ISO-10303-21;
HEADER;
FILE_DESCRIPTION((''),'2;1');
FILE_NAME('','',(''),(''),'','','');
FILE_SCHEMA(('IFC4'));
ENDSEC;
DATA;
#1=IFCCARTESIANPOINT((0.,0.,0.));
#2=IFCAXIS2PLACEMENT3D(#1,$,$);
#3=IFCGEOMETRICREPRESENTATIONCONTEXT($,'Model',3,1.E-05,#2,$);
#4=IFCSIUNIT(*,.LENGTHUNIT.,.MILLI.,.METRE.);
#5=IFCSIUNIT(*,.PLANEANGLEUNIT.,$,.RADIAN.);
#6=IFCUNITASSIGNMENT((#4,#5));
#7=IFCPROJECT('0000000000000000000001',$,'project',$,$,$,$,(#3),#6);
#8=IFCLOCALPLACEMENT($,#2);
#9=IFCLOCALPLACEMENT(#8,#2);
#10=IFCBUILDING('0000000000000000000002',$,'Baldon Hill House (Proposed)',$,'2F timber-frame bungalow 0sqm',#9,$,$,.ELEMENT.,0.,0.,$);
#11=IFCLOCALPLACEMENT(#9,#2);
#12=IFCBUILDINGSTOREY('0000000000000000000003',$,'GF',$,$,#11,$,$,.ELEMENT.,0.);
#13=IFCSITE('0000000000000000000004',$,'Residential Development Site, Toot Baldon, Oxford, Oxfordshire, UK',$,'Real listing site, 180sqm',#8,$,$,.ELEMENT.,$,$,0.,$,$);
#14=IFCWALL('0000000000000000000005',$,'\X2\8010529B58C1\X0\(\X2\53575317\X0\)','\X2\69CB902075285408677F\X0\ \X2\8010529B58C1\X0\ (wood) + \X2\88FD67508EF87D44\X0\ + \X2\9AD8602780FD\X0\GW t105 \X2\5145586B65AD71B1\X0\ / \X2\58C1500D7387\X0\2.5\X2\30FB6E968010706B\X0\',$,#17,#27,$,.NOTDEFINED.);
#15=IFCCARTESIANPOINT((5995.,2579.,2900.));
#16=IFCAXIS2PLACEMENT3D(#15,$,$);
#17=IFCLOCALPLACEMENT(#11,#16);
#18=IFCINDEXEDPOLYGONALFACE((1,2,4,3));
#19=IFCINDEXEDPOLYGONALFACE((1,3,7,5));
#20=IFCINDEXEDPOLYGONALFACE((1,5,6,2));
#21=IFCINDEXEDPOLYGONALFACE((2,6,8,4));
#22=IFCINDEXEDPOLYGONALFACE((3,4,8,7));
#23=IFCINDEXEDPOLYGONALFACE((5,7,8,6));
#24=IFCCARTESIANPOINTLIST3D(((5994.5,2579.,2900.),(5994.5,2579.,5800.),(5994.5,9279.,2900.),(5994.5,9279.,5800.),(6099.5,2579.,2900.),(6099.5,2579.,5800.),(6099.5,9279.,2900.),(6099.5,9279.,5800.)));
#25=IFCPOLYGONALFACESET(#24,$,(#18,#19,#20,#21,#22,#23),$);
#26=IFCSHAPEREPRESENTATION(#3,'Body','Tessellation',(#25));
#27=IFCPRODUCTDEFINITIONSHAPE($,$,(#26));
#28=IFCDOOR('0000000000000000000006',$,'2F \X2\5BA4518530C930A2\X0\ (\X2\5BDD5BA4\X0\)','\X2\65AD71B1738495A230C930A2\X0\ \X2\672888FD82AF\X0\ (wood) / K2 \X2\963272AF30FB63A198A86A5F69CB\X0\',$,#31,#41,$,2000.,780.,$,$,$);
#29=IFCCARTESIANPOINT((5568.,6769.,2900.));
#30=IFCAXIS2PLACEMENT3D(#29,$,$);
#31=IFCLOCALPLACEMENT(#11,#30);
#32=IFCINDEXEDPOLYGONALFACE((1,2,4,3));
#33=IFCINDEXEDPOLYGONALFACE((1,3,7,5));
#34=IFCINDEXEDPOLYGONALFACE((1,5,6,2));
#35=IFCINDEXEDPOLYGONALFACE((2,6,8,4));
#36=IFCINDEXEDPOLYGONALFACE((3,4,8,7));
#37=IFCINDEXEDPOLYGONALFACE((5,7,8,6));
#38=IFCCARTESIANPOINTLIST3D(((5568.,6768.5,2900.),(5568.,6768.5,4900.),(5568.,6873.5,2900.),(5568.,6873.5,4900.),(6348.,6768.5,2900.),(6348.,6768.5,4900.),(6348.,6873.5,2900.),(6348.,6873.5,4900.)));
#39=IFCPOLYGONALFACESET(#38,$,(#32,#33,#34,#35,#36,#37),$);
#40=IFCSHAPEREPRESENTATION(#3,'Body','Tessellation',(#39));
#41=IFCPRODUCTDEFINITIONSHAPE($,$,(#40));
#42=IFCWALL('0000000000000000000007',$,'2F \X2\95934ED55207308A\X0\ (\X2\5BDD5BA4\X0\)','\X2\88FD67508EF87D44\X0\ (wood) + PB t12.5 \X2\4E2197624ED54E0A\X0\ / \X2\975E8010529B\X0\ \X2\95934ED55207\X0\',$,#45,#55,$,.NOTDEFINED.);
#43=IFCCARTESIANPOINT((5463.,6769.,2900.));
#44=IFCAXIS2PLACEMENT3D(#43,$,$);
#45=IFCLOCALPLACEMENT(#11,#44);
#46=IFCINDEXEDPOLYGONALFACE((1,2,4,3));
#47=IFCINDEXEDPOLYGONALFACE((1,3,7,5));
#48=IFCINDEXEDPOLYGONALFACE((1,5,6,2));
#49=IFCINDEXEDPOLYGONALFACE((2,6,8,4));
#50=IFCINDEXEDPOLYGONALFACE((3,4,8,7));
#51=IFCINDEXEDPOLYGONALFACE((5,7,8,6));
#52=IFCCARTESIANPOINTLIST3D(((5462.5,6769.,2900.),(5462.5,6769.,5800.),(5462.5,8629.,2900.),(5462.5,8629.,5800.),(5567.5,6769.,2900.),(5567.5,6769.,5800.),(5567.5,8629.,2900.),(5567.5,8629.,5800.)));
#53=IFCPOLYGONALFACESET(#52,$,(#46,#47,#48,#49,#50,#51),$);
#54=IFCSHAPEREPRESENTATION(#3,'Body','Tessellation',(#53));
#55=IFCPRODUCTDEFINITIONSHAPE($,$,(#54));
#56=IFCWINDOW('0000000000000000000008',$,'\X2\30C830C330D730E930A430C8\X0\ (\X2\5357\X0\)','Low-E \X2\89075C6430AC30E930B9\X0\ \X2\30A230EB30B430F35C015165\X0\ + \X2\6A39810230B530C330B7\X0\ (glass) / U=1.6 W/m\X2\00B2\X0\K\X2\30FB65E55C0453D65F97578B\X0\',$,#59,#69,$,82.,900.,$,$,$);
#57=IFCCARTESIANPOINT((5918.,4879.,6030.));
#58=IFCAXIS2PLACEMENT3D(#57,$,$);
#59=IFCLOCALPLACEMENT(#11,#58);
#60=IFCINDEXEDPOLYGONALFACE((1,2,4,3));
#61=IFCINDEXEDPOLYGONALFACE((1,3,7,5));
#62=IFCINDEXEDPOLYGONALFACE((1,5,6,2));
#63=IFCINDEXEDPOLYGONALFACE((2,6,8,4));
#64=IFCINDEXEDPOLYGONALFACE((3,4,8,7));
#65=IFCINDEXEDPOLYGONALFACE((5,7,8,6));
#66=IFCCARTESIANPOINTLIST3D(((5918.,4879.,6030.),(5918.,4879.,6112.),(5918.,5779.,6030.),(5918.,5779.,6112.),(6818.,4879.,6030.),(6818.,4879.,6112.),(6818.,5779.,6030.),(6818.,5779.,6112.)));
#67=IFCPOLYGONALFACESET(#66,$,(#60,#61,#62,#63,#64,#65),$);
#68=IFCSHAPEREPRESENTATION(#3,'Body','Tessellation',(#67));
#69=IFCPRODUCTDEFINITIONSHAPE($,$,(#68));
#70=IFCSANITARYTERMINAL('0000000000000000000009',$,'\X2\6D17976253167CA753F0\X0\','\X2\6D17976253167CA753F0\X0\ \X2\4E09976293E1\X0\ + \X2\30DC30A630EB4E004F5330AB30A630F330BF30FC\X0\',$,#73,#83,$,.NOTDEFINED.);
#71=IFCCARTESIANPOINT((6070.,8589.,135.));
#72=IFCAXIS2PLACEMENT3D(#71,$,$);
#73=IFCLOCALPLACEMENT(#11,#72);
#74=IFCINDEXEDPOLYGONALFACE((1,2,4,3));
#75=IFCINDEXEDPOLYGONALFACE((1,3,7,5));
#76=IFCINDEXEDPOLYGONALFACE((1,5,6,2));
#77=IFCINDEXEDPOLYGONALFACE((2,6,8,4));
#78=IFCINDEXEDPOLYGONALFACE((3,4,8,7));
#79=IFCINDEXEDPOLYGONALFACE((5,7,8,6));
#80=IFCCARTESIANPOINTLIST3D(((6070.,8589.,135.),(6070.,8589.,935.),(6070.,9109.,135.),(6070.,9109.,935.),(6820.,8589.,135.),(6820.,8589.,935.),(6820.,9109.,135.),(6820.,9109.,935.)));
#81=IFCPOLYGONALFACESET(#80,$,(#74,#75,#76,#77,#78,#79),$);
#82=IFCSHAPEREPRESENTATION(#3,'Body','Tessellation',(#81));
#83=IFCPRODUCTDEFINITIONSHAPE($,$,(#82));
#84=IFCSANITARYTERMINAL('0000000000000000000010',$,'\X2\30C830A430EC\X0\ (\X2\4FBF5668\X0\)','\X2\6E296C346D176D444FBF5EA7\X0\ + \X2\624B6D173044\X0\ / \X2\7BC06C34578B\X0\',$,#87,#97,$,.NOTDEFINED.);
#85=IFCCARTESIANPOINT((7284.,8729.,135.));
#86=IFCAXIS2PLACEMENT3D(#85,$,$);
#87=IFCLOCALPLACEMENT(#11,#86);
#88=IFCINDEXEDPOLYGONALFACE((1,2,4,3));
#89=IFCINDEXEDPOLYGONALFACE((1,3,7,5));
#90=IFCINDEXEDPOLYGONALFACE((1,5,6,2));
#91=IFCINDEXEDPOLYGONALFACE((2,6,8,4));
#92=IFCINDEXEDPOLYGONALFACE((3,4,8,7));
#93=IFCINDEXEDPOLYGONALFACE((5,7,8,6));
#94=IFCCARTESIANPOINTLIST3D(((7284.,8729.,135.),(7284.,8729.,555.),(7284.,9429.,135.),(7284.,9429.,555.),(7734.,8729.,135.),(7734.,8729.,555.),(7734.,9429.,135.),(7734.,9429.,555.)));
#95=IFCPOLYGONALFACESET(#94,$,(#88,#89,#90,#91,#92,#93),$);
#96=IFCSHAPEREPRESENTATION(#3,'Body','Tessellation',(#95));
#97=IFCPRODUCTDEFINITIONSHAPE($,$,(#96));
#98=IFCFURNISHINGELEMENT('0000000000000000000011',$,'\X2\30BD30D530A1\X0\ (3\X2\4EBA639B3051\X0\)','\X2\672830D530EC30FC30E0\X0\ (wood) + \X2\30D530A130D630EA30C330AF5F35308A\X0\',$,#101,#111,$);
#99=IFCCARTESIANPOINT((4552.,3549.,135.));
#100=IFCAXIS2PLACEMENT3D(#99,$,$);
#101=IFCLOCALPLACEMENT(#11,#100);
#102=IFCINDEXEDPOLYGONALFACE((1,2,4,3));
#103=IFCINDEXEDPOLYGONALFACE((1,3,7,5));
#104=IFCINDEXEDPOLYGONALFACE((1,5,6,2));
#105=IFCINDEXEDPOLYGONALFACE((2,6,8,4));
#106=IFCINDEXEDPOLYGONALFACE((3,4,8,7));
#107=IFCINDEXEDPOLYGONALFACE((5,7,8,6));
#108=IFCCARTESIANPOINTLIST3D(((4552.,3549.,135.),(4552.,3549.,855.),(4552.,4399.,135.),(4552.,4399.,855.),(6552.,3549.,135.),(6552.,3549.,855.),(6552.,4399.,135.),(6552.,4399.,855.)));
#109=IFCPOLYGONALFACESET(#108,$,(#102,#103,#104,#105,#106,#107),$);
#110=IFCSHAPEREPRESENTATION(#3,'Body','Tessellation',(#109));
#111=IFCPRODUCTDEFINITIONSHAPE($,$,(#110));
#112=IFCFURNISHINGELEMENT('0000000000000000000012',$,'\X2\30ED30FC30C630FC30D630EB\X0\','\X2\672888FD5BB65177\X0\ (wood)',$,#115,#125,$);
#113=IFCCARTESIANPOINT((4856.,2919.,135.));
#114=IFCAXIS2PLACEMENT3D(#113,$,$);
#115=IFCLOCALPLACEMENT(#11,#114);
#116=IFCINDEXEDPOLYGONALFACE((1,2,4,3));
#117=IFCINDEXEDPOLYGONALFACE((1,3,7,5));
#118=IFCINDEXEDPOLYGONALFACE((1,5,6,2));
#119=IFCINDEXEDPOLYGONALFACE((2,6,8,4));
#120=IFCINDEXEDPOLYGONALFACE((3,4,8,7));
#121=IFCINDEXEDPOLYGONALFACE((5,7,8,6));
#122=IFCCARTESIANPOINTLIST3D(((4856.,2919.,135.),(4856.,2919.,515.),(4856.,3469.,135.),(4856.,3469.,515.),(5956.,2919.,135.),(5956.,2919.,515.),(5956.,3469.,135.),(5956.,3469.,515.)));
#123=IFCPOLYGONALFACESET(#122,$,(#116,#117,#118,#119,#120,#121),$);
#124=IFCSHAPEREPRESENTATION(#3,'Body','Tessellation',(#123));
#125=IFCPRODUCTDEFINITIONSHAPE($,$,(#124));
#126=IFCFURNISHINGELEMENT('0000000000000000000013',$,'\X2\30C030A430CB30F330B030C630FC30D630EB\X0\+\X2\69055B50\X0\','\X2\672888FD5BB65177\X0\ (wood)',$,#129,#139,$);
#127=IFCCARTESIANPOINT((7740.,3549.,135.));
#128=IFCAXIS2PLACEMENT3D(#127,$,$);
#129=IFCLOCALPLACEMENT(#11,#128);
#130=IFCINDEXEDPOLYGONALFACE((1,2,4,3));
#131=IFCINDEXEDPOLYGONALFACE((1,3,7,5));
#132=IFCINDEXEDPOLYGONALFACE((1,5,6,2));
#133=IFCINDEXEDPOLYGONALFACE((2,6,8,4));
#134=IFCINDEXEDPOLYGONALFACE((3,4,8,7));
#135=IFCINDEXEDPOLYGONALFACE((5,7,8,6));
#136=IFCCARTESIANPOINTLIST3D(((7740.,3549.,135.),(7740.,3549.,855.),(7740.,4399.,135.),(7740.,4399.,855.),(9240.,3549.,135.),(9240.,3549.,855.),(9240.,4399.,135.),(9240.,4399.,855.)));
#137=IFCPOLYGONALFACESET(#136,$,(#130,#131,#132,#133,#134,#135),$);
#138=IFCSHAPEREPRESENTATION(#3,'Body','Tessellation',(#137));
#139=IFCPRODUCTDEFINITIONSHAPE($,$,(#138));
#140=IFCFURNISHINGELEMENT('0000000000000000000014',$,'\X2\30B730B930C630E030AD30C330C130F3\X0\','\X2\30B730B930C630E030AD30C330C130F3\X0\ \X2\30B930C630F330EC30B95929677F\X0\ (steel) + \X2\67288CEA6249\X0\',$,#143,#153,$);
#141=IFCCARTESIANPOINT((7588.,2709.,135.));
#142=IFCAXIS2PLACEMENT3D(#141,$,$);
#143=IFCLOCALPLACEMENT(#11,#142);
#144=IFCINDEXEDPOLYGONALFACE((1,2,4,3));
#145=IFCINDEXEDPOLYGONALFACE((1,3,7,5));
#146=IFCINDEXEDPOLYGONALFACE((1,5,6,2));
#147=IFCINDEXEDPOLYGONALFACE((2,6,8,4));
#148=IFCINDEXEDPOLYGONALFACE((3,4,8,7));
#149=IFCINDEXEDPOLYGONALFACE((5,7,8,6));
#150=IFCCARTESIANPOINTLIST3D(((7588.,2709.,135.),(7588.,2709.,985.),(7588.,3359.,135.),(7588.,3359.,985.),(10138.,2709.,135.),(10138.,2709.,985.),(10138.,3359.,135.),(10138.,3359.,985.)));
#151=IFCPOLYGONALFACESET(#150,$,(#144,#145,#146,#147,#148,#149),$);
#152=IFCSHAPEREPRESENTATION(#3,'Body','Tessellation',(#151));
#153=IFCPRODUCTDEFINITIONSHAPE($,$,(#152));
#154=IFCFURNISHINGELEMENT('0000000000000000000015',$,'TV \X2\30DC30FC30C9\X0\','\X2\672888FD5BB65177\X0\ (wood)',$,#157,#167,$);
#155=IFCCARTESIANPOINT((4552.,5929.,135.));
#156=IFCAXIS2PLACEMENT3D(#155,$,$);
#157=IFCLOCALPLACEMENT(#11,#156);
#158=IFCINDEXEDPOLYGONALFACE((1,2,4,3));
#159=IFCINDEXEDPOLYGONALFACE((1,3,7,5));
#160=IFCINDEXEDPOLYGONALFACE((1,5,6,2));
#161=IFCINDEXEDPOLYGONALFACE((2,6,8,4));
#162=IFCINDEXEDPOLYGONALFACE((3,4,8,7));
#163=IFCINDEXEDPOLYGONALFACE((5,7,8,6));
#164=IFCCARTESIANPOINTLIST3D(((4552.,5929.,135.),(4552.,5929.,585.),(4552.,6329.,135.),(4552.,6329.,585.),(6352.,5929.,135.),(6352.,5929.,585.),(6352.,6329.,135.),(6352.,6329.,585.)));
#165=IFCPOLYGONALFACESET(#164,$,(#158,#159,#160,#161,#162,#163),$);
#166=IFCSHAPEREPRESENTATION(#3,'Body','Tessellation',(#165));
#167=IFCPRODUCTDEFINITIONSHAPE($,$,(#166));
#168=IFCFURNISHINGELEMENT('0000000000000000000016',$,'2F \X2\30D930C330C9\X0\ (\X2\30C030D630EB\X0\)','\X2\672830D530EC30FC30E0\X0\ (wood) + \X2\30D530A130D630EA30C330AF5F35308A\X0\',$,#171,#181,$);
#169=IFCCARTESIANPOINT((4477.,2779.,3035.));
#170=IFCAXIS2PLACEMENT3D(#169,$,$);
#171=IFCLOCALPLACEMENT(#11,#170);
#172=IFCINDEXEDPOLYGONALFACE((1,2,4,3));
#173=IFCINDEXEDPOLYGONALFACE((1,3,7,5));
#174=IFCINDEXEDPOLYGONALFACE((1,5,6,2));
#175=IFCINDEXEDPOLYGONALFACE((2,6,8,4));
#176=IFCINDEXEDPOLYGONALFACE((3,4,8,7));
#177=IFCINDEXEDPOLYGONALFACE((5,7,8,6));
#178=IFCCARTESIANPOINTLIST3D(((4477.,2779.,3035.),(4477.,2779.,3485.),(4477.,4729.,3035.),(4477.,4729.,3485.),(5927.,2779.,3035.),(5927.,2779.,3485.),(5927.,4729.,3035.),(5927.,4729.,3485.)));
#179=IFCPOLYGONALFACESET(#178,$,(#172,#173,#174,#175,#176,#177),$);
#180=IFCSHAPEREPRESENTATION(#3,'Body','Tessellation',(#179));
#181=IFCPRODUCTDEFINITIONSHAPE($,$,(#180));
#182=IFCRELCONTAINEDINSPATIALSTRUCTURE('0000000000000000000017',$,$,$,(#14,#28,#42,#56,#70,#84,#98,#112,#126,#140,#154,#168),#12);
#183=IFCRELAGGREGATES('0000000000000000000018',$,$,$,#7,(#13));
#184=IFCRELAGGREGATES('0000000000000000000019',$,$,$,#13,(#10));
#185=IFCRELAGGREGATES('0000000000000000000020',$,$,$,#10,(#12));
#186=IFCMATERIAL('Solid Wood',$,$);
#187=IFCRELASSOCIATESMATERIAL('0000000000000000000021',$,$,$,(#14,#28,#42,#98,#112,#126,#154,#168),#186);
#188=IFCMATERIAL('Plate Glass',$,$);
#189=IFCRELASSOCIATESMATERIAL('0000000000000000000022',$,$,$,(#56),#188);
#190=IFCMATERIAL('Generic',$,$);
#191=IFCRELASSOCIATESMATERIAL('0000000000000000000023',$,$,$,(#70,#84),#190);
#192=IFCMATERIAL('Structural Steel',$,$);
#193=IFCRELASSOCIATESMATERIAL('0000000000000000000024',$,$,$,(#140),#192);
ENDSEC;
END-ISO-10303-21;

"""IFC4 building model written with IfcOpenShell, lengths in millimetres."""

from ifc_helpers import new_model, si_unit, frame, frame_2d, origin, place, context, project, spatial, rectangle, extrude, material, element, fill, save


model = new_model("IFC4")

# Units and contexts
model_context = context("Model", 3, precision=1e-05, world=origin())
ifc_project = project(units=[si_unit("LENGTHUNIT", "METRE", prefix="MILLI"), si_unit("PLANEANGLEUNIT", "RADIAN")], contexts=[model_context])

# Site, building, storey
site_placement = place(None, origin())
site = spatial("IfcSite", under=ifc_project, at=site_placement, Name="Residential Development Site, Toot Baldon, Oxford, Oxfordshire, UK", ObjectType="Real listing site, 180sqm", CompositionType="ELEMENT", RefElevation=0.0)
building_placement = place(site_placement, origin())
building = spatial("IfcBuilding", under=site, at=building_placement, Name="Baldon Hill House (Proposed)", ObjectType="2F timber-frame bungalow 0sqm", CompositionType="ELEMENT", ElevationOfRefHeight=0.0, ElevationOfTerrain=0.0)
storey_placement = place(building_placement, origin())
storey = spatial("IfcBuildingStorey", under=building, at=storey_placement, Name="GF", CompositionType="ELEMENT", Elevation=0.0)

# Shared definitions
ifc_material_1 = material(Name="Solid Wood")

# Wall, opening, door
wall_1_placement = place(storey_placement, frame((5995.0, 2579.0, 2900.0)))
wall_1 = element("IfcWall", 1, at=wall_1_placement, inside=storey, material=ifc_material_1, Name="耐力壁(南北)", Description="構造用合板 耐力壁 (wood) + 製材軸組 + 高性能GW t105 充填断熱 / 壁倍率2.5・準耐火", PredefinedType="NOTDEFINED", context=model_context, shape_type="SweptSolid", body=[
    extrude(rectangle(XDim=105.0, YDim=6700.0, at=frame_2d((52.0, 3350.0))), frame((5995.0, 2579.0, 2900.0)), (0.0, 0.0, 1.0), 2900.0),
])
opening_1_placement = place(storey_placement, frame((5568.0, 6769.0, 2900.0)))
opening_1 = element("IfcOpeningElement", 2, at=opening_1_placement, cuts=wall_1, PredefinedType="NOTDEFINED", context=model_context, shape_type="SweptSolid", body=[
    extrude(rectangle(XDim=780.0, YDim=105.0, at=frame_2d((390.0, 52.0))), frame((5568.0, 6769.0, 2900.0)), (0.0, 0.0, 1.0), 2000.0),
])
door_1_placement = place(storey_placement, frame((5568.0, 6769.0, 2900.0)))
door_1 = element("IfcDoor", 3, at=door_1_placement, inside=storey, material=ifc_material_1, Name="2F 室内ドア (寝室)", Description="断熱玄関ドア 木製芯 (wood) / K2 防犯・採風機構", OverallHeight=2000.0, OverallWidth=780.0, context=model_context, shape_type="SweptSolid", body=[
    extrude(rectangle(XDim=780.0, YDim=105.0, at=frame_2d((390.0, 52.0))), frame((5568.0, 6769.0, 2900.0)), (0.0, 0.0, 1.0), 2000.0),
])
fill(opening_1, door_1)

# Wall
wall_2_placement = place(storey_placement, frame((5463.0, 6769.0, 2900.0)))
element("IfcWall", 4, at=wall_2_placement, inside=storey, material=ifc_material_1, Name="2F 間仕切り (寝室)", Description="製材軸組 (wood) + PB t12.5 両面仕上 / 非耐力 間仕切", PredefinedType="NOTDEFINED", context=model_context, shape_type="SweptSolid", body=[
    extrude(rectangle(XDim=105.0, YDim=1860.0, at=frame_2d((52.0, 930.0))), frame((5463.0, 6769.0, 2900.0)), (0.0, 0.0, 1.0), 2900.0),
])

# Window
ifc_material_2 = material(Name="Plate Glass")
window_placement = place(storey_placement, frame((5918.0, 4879.0, 6030.0)))
element("IfcWindow", 5, at=window_placement, inside=storey, material=ifc_material_2, Name="トップライト (南)", Description="Low-E 複層ガラス アルゴン封入 + 樹脂サッシ (glass) / U=1.6 W/m²K・日射取得型", OverallHeight=82.0, OverallWidth=900.0, context=model_context, shape_type="SweptSolid", body=[
    extrude(rectangle(XDim=900.0, YDim=900.0, at=frame_2d((450.0, 450.0))), frame((5918.0, 4879.0, 6030.0)), (0.0, 0.0, 1.0), 82.0),
])

# Sanitary terminals
ifc_material_3 = material(Name="Generic")
sanitary_terminal_1_placement = place(storey_placement, frame((6070.0, 8589.0, 135.0)))
element("IfcSanitaryTerminal", 6, at=sanitary_terminal_1_placement, inside=storey, material=ifc_material_3, Name="洗面化粧台", Description="洗面化粧台 三面鏡 + ボウル一体カウンター", PredefinedType="NOTDEFINED", context=model_context, shape_type="SweptSolid", body=[
    extrude(rectangle(XDim=750.0, YDim=520.0, at=frame_2d((375.0, 260.0))), frame((6070.0, 8589.0, 135.0)), (0.0, 0.0, 1.0), 800.0),
])
sanitary_terminal_2_placement = place(storey_placement, frame((7284.0, 8729.0, 135.0)))
element("IfcSanitaryTerminal", 7, at=sanitary_terminal_2_placement, inside=storey, material=ifc_material_3, Name="トイレ (便器)", Description="温水洗浄便座 + 手洗い / 節水型", PredefinedType="NOTDEFINED", context=model_context, shape_type="SweptSolid", body=[
    extrude(rectangle(XDim=450.0, YDim=700.0, at=frame_2d((225.0, 350.0))), frame((7284.0, 8729.0, 135.0)), (0.0, 0.0, 1.0), 420.0),
])

# Furnishing elements
furnishing_1_placement = place(storey_placement, frame((4552.0, 3549.0, 135.0)))
element("IfcFurnishingElement", 8, at=furnishing_1_placement, inside=storey, material=ifc_material_1, Name="ソファ (3人掛け)", Description="木フレーム (wood) + ファブリック張り", context=model_context, shape_type="SweptSolid", body=[
    extrude(rectangle(XDim=2000.0, YDim=850.0, at=frame_2d((1000.0, 425.0))), frame((4552.0, 3549.0, 135.0)), (0.0, 0.0, 1.0), 720.0),
])
furnishing_2_placement = place(storey_placement, frame((4856.0, 2919.0, 135.0)))
element("IfcFurnishingElement", 9, at=furnishing_2_placement, inside=storey, material=ifc_material_1, Name="ローテーブル", Description="木製家具 (wood)", context=model_context, shape_type="SweptSolid", body=[
    extrude(rectangle(XDim=1100.0, YDim=550.0, at=frame_2d((550.0, 275.0))), frame((4856.0, 2919.0, 135.0)), (0.0, 0.0, 1.0), 380.0),
])
furnishing_3_placement = place(storey_placement, frame((7740.0, 3549.0, 135.0)))
element("IfcFurnishingElement", 10, at=furnishing_3_placement, inside=storey, material=ifc_material_1, Name="ダイニングテーブル+椅子", Description="木製家具 (wood)", context=model_context, shape_type="SweptSolid", body=[
    extrude(rectangle(XDim=1500.0, YDim=850.0, at=frame_2d((750.0, 425.0))), frame((7740.0, 3549.0, 135.0)), (0.0, 0.0, 1.0), 720.0),
])
ifc_material_4 = material(Name="Structural Steel")
furnishing_4_placement = place(storey_placement, frame((7588.0, 2709.0, 135.0)))
element("IfcFurnishingElement", 11, at=furnishing_4_placement, inside=storey, material=ifc_material_4, Name="システムキッチン", Description="システムキッチン ステンレス天板 (steel) + 木質扉", context=model_context, shape_type="SweptSolid", body=[
    extrude(rectangle(XDim=2550.0, YDim=650.0, at=frame_2d((1275.0, 325.0))), frame((7588.0, 2709.0, 135.0)), (0.0, 0.0, 1.0), 850.0),
])
furnishing_5_placement = place(storey_placement, frame((4552.0, 5929.0, 135.0)))
element("IfcFurnishingElement", 12, at=furnishing_5_placement, inside=storey, material=ifc_material_1, Name="TV ボード", Description="木製家具 (wood)", context=model_context, shape_type="SweptSolid", body=[
    extrude(rectangle(XDim=1800.0, YDim=400.0, at=frame_2d((900.0, 200.0))), frame((4552.0, 5929.0, 135.0)), (0.0, 0.0, 1.0), 450.0),
])
furnishing_6_placement = place(storey_placement, frame((4477.0, 2779.0, 3035.0)))
element("IfcFurnishingElement", 13, at=furnishing_6_placement, inside=storey, material=ifc_material_1, Name="2F ベッド (ダブル)", Description="木フレーム (wood) + ファブリック張り", context=model_context, shape_type="SweptSolid", body=[
    extrude(rectangle(XDim=1450.0, YDim=1950.0, at=frame_2d((725.0, 975.0))), frame((4477.0, 2779.0, 3035.0)), (0.0, 0.0, 1.0), 450.0),
])

save(model, "model.ifc")
